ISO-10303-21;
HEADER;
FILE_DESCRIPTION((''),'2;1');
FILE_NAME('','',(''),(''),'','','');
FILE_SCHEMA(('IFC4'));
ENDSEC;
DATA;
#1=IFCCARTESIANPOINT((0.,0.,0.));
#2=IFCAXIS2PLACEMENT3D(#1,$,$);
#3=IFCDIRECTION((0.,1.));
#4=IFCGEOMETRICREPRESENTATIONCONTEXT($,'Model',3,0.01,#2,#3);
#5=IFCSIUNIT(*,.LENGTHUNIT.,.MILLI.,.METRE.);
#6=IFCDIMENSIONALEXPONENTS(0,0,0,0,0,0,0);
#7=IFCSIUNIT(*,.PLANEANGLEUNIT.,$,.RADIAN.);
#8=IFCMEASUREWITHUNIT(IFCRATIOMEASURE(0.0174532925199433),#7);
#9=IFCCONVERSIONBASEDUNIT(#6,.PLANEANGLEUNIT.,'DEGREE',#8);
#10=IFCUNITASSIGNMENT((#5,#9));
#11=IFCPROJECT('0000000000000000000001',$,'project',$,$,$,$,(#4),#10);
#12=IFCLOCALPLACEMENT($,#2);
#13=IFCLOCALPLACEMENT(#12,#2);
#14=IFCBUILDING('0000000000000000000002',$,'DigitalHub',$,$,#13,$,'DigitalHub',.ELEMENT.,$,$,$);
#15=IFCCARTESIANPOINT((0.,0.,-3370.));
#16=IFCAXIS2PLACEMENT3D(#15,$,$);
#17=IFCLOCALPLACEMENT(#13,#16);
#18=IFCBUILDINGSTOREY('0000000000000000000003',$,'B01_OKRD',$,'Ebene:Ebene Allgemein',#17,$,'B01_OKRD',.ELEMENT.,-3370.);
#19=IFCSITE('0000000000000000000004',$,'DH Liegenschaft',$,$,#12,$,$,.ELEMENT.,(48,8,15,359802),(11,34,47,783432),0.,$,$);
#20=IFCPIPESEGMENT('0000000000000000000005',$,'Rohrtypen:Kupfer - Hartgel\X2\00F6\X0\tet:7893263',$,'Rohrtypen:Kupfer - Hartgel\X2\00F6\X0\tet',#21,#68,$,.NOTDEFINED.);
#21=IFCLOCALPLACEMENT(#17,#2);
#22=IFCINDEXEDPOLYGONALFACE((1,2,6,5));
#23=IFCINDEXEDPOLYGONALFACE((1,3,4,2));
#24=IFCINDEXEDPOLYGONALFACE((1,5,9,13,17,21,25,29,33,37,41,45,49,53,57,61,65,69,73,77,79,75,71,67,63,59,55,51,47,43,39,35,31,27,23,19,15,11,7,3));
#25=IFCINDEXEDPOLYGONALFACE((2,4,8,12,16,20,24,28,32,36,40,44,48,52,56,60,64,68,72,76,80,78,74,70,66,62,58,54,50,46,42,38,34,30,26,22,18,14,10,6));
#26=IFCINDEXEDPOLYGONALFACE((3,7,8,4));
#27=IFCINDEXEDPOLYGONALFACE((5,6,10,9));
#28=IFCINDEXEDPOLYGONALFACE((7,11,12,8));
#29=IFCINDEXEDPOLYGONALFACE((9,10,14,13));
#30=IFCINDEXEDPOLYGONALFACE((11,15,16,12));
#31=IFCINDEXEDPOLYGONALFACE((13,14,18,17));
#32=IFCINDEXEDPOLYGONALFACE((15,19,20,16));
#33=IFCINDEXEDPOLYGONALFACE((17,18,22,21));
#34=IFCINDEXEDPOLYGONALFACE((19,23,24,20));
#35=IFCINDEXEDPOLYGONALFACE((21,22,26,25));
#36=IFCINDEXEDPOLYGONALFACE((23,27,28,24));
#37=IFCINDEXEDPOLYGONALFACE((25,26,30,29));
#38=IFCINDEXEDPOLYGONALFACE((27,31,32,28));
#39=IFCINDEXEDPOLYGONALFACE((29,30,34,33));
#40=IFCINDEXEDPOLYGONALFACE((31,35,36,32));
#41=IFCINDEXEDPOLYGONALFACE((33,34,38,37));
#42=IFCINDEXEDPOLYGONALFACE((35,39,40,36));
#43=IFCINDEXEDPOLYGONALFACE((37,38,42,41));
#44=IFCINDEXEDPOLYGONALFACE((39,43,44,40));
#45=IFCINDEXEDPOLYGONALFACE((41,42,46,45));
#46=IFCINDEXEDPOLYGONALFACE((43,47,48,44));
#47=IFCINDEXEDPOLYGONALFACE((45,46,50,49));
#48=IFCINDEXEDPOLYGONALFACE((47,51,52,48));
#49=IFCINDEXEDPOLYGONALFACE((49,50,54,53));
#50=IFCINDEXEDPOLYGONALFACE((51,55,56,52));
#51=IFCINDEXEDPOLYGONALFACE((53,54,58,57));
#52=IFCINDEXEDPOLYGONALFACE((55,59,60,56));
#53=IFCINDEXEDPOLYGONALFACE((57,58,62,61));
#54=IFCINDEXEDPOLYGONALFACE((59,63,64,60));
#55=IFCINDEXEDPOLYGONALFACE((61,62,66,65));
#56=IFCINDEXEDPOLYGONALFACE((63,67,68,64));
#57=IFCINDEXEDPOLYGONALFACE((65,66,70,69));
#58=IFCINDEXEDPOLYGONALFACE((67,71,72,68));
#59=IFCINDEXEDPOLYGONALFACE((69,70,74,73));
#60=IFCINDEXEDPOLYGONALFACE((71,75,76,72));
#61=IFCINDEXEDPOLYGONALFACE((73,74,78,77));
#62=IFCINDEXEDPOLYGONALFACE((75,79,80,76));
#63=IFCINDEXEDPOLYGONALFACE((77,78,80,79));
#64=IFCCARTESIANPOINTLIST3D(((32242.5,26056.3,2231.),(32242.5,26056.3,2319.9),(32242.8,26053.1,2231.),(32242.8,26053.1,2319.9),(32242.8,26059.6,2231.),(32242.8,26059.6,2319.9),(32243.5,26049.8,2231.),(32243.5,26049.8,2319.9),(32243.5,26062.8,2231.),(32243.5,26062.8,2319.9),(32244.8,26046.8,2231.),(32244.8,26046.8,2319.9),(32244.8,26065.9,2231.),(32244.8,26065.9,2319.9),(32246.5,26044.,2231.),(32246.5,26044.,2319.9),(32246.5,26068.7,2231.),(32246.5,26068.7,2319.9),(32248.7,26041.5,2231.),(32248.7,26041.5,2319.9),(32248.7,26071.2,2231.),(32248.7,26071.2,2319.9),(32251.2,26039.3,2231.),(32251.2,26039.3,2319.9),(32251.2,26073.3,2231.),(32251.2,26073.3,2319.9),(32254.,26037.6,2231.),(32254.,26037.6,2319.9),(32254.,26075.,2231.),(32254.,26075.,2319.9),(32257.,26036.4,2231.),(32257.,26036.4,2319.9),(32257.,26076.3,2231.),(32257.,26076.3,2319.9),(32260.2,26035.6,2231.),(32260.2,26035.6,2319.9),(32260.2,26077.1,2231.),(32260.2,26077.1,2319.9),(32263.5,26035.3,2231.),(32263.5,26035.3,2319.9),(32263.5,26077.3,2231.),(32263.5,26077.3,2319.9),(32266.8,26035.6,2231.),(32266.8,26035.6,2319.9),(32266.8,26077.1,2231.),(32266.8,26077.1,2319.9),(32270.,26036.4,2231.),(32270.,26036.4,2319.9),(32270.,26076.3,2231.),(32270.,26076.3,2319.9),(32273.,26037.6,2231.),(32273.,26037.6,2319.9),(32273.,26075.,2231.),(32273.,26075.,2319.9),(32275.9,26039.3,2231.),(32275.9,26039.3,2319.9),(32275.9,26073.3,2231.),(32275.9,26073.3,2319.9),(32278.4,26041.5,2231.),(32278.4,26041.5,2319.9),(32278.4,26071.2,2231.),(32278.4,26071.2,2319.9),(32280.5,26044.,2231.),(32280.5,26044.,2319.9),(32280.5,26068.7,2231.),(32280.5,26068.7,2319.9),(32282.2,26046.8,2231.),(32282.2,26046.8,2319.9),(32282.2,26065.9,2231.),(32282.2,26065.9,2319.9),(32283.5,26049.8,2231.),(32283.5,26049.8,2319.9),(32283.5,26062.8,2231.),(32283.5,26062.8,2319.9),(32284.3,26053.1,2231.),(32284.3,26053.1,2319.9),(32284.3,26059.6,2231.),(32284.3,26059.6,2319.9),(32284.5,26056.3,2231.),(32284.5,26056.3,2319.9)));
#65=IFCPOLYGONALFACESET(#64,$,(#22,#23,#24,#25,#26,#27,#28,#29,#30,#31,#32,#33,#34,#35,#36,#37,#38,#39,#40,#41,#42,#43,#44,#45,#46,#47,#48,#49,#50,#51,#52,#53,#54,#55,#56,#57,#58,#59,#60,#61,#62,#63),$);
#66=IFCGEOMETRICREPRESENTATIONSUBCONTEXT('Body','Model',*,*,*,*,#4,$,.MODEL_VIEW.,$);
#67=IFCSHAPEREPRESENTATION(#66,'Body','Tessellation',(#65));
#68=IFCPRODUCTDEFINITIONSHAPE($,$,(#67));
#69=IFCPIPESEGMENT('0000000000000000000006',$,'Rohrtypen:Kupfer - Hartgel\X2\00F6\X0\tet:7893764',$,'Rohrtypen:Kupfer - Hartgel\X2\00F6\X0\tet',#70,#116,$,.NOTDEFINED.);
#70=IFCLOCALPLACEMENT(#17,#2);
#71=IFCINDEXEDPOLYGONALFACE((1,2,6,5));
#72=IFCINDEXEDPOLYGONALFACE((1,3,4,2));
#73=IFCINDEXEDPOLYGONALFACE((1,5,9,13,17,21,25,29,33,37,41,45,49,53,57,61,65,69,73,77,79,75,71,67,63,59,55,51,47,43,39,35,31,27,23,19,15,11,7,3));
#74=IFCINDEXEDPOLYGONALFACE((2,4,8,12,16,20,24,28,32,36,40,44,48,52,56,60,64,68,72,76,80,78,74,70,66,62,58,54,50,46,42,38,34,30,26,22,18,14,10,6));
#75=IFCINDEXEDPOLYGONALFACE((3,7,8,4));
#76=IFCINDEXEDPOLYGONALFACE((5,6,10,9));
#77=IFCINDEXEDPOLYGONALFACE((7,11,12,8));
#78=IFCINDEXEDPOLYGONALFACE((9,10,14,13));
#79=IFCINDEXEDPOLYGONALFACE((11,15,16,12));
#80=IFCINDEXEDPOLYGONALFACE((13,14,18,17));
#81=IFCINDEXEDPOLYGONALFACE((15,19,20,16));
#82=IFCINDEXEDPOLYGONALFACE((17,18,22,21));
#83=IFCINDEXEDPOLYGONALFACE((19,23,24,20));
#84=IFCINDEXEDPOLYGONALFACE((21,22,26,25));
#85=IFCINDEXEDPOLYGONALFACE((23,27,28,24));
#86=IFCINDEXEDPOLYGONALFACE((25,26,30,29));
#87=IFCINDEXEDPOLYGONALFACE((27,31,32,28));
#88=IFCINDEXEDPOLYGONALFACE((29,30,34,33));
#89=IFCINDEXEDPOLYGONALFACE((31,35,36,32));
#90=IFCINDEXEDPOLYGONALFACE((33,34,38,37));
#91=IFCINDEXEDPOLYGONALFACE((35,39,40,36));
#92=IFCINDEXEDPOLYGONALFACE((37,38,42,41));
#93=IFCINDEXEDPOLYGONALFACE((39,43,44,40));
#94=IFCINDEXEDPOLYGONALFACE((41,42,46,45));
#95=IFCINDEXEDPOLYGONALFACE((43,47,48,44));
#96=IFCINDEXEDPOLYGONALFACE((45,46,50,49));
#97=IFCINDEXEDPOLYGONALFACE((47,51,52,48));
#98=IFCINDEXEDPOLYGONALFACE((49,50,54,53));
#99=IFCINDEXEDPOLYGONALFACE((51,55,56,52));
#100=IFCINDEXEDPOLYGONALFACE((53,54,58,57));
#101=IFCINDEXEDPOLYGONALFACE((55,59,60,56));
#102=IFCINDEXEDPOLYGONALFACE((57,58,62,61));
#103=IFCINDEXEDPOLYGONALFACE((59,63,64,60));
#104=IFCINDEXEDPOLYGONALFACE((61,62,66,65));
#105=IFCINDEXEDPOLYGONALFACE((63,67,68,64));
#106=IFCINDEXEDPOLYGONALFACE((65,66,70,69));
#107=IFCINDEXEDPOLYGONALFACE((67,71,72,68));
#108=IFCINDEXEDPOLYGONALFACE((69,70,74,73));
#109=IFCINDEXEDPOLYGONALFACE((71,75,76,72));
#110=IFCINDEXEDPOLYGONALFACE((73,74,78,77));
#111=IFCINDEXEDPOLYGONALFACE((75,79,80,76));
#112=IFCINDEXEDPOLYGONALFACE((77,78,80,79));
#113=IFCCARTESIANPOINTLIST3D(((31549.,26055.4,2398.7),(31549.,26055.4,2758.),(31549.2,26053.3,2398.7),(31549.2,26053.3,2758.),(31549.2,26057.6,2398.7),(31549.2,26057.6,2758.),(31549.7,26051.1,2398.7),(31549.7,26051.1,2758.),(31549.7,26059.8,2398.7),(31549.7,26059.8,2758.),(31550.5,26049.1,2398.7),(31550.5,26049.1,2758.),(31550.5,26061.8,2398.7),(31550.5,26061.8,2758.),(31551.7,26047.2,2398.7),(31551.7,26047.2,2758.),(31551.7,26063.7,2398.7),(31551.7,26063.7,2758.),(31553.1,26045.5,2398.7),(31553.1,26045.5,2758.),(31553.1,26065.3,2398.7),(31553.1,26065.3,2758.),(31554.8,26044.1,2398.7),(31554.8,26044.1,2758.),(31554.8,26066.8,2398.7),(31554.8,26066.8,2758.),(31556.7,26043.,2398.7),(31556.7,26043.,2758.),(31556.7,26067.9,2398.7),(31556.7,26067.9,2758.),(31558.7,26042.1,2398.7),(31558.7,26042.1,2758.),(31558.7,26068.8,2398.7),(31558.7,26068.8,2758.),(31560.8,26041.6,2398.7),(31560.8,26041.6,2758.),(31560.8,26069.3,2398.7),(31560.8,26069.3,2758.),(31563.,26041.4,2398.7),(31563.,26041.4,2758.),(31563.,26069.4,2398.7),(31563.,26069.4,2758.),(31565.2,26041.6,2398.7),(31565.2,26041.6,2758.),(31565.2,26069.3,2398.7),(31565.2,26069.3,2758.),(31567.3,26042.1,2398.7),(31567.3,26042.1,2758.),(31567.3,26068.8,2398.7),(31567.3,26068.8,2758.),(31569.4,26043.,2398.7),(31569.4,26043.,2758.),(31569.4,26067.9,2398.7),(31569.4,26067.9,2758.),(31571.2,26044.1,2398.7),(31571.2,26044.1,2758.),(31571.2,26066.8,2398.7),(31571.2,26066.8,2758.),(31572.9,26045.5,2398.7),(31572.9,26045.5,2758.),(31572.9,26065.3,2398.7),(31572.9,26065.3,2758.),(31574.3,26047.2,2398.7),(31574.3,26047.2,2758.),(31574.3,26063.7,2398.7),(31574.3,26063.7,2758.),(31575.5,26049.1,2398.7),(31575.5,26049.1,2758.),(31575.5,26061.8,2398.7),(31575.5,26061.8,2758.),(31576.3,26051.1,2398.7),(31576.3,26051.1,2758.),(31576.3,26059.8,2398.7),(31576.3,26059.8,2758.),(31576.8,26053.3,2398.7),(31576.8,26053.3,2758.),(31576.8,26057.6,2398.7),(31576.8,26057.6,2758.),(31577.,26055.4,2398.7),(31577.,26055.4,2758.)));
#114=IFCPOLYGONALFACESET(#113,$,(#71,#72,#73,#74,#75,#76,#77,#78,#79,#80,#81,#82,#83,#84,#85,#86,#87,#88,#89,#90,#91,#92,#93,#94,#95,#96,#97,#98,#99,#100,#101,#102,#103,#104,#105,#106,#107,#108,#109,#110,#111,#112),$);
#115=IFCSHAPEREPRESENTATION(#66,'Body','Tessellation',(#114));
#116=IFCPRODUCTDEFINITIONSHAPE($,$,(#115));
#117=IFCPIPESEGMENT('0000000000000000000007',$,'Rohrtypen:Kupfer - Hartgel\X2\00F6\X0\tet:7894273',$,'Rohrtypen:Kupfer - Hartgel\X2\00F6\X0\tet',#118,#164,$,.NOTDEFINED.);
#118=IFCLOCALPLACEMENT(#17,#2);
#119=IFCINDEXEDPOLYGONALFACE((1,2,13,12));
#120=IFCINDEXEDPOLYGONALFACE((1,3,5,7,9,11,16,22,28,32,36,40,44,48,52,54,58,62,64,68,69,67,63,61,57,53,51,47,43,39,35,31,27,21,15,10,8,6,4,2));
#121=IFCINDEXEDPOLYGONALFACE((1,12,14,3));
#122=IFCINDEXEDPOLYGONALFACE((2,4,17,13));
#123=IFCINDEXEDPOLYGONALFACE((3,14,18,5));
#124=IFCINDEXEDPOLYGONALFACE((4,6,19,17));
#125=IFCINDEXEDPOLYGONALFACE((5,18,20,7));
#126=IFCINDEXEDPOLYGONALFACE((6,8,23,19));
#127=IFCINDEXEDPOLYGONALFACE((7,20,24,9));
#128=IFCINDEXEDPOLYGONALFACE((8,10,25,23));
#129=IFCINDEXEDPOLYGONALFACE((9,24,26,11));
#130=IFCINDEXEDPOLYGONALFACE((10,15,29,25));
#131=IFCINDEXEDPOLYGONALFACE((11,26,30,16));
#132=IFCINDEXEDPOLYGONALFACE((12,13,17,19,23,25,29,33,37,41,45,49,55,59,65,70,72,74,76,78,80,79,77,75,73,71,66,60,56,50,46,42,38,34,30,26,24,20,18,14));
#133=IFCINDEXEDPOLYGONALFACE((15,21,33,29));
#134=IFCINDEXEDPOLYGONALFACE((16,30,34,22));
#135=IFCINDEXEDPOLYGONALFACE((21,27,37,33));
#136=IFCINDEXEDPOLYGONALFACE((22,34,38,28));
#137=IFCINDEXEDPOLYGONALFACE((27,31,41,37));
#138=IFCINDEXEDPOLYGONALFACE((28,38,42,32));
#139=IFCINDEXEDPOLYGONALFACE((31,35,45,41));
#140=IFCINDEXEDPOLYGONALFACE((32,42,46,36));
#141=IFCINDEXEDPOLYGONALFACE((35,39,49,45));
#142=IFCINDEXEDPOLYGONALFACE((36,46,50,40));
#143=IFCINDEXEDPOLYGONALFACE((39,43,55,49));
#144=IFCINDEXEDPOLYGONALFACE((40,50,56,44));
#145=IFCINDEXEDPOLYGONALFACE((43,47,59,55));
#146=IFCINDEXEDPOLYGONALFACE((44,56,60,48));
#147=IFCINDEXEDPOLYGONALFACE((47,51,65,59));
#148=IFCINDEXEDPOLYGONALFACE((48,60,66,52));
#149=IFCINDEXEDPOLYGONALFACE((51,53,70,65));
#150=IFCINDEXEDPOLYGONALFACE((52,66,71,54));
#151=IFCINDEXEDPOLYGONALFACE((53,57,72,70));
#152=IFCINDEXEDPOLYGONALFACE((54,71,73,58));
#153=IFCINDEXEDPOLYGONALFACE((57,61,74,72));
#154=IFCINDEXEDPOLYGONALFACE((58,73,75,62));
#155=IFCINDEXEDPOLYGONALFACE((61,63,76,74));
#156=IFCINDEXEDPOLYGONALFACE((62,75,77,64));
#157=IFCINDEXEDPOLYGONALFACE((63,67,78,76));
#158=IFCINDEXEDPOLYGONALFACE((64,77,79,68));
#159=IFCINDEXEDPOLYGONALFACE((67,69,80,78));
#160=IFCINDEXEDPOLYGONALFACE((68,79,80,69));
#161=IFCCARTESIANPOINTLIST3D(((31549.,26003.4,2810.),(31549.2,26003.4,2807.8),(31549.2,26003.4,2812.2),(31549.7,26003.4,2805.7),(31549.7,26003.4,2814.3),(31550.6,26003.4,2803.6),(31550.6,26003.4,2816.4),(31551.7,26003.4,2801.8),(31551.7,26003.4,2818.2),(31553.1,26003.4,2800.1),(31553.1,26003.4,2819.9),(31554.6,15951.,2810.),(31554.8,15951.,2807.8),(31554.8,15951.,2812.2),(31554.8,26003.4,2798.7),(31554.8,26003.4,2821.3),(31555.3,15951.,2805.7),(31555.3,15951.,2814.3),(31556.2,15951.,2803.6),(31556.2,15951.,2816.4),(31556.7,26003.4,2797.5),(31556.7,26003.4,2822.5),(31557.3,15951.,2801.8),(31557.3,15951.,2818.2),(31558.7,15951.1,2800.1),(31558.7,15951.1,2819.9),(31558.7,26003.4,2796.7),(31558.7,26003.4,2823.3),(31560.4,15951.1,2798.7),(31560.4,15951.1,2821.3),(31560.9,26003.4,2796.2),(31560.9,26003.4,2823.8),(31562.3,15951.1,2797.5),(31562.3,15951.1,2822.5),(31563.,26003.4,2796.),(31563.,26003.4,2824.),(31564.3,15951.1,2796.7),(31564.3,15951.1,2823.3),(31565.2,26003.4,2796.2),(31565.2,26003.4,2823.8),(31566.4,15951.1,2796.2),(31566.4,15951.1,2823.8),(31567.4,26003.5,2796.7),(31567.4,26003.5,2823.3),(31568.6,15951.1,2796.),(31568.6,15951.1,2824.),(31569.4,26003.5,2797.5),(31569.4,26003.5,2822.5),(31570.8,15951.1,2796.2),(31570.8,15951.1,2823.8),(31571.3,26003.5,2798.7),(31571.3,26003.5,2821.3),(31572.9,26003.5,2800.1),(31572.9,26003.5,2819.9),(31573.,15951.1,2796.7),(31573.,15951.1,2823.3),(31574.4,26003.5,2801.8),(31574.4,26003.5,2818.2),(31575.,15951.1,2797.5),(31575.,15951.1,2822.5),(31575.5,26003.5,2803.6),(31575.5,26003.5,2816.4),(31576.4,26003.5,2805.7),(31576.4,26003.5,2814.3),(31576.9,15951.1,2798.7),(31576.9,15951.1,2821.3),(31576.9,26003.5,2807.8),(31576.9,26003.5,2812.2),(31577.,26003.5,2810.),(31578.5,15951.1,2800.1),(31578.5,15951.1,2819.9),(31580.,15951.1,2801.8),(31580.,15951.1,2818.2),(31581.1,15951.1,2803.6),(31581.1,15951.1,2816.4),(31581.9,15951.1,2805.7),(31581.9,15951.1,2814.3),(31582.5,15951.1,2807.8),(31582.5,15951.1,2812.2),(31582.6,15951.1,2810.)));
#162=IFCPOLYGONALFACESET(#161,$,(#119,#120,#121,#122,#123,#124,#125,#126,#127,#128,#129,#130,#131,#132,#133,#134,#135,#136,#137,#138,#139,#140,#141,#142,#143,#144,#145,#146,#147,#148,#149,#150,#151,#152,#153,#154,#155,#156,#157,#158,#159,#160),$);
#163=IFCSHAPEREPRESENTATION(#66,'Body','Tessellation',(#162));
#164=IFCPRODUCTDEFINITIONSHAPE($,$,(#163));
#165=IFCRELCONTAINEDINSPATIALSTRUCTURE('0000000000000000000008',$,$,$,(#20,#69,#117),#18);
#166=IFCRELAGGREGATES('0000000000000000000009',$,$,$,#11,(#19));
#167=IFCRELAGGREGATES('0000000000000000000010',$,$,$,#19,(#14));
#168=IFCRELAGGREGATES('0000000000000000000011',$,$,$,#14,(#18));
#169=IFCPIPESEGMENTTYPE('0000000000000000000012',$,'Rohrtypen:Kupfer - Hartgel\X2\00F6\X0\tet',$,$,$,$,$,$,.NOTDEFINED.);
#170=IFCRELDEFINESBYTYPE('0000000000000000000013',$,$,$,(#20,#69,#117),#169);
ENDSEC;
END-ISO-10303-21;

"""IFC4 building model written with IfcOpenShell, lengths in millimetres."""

from ifc_helpers import new_model, entity, si_unit, converted_unit, direction, frame, origin, place, context, subcontext, project, spatial, indexed_curve, outline, extrude, type_object, element, save


model = new_model("IFC4")

# Units and contexts
model_context = context("Model", 3, precision=0.01, world=origin(), true_north=direction((0.0, 1.0)))
body_context = subcontext(model_context, "Body", "Model", "MODEL_VIEW")
ifc_project = project(units=[si_unit("LENGTHUNIT", "METRE", prefix="MILLI"), converted_unit("PLANEANGLEUNIT", "DEGREE", entity("IfcRatioMeasure", 0.0174532925199433), si_unit("PLANEANGLEUNIT", "RADIAN"), dimensions=[0, 0, 0, 0, 0, 0, 0])], contexts=[model_context])

# Site, building, storey
site_placement = place(None, origin())
site = spatial("IfcSite", under=ifc_project, at=site_placement, Name="DH Liegenschaft", CompositionType="ELEMENT", RefLatitude=(48, 8, 15, 359802), RefLongitude=(11, 34, 47, 783432), RefElevation=0.0)
building_placement = place(site_placement, origin())
building = spatial("IfcBuilding", under=site, at=building_placement, Name="DigitalHub", LongName="DigitalHub", CompositionType="ELEMENT")
storey_placement = place(building_placement, frame((0.0, 0.0, -3370.0)))
storey = spatial("IfcBuildingStorey", under=building, at=storey_placement, Name="B01_OKRD", ObjectType="Ebene:Ebene Allgemein", LongName="B01_OKRD", CompositionType="ELEMENT", Elevation=-3370.0)

# Pipe segments
pipe_segment_type = type_object("IfcPipeSegmentType", Name="Rohrtypen:Kupfer - Hartgelötet", PredefinedType="NOTDEFINED")
pipe_segment_1_placement = place(storey_placement, frame((32240.9, 26033.7, 2231.0)))
element("IfcPipeSegment", 1, at=pipe_segment_1_placement, inside=storey, type_object=pipe_segment_type, Name="Rohrtypen:Kupfer - Hartgelötet:7893263", ObjectType="Rohrtypen:Kupfer - Hartgelötet", PredefinedType="NOTDEFINED", context=body_context, shape_type="SweptSolid", body=[
    extrude(outline(indexed_curve([(21.0, 0.0), (20.7, 3.3), (20.0, 6.5), (18.7, 9.5), (17.0, 12.3), (14.8, 14.8), (12.3, 17.0), (9.5, 18.7), (6.5, 20.0), (3.3, 20.7), (0.0, 21.0), (-3.3, 20.7), (-6.5, 20.0), (-9.5, 18.7), (-12.3, 17.0), (-14.8, 14.8), (-17.0, 12.3), (-18.7, 9.5), (-20.0, 6.5), (-20.7, 3.3), (-21.0, 0.0), (-20.7, -3.3), (-20.0, -6.5), (-18.7, -9.5), (-17.0, -12.3), (-14.8, -14.8), (-12.3, -17.0), (-9.5, -18.7), (-6.5, -20.0), (-3.3, -20.7), (0.0, -21.0), (3.3, -20.7), (6.5, -20.0), (9.5, -18.7), (12.3, -17.0), (14.8, -14.8), (17.0, -12.3), (18.7, -9.5), (20.0, -6.5), (20.7, -3.3), (21.0, 0.0)], self_intersect=False)), frame((22.6, 22.6, 0.0)), (0.0, 0.0, 1.0), 89.0),
])
pipe_segment_2_placement = place(storey_placement, frame((31547.4, 26039.9, 2398.7)))
element("IfcPipeSegment", 2, at=pipe_segment_2_placement, inside=storey, type_object=pipe_segment_type, Name="Rohrtypen:Kupfer - Hartgelötet:7893764", ObjectType="Rohrtypen:Kupfer - Hartgelötet", PredefinedType="NOTDEFINED", context=body_context, shape_type="SweptSolid", body=[
    extrude(outline(indexed_curve([(14.0, 0.0), (13.8, 2.2), (13.3, 4.3), (12.5, 6.4), (11.3, 8.2), (9.9, 9.9), (8.2, 11.3), (6.4, 12.5), (4.3, 13.3), (2.2, 13.8), (0.0, 14.0), (-2.2, 13.8), (-4.3, 13.3), (-6.4, 12.5), (-8.2, 11.3), (-9.9, 9.9), (-11.3, 8.2), (-12.5, 6.4), (-13.3, 4.3), (-13.8, 2.2), (-14.0, 0.0), (-13.8, -2.2), (-13.3, -4.3), (-12.5, -6.4), (-11.3, -8.2), (-9.9, -9.9), (-8.2, -11.3), (-6.4, -12.5), (-4.3, -13.3), (-2.2, -13.8), (0.0, -14.0), (2.2, -13.8), (4.3, -13.3), (6.4, -12.5), (8.2, -11.3), (9.9, -9.9), (11.3, -8.2), (12.5, -6.4), (13.3, -4.3), (13.8, -2.2), (14.0, 0.0)], self_intersect=False)), frame((15.6, 15.6, 0.0), z_axis=(0.0, 0.0, 1.0), x_axis=(-1.0, 0.0, 0.0)), (0.0, 0.0, 1.0), 359.3),
])
pipe_segment_3_placement = place(storey_placement, frame((31547.4, 15951.0, 2794.4)))
element("IfcPipeSegment", 3, at=pipe_segment_3_placement, inside=storey, type_object=pipe_segment_type, Name="Rohrtypen:Kupfer - Hartgelötet:7894273", ObjectType="Rohrtypen:Kupfer - Hartgelötet", PredefinedType="NOTDEFINED", context=body_context, shape_type="SweptSolid", body=[
    extrude(outline(indexed_curve([(14.0, 0.0), (13.8, 2.2), (13.3, 4.3), (12.5, 6.4), (11.3, 8.2), (9.9, 9.9), (8.2, 11.3), (6.4, 12.5), (4.3, 13.3), (2.2, 13.8), (0.0, 14.0), (-2.2, 13.8), (-4.3, 13.3), (-6.4, 12.5), (-8.2, 11.3), (-9.9, 9.9), (-11.3, 8.2), (-12.5, 6.4), (-13.3, 4.3), (-13.8, 2.2), (-14.0, 0.0), (-13.8, -2.2), (-13.3, -4.3), (-12.5, -6.4), (-11.3, -8.2), (-9.9, -9.9), (-8.2, -11.3), (-6.4, -12.5), (-4.3, -13.3), (-2.2, -13.8), (0.0, -14.0), (2.2, -13.8), (4.3, -13.3), (6.4, -12.5), (8.2, -11.3), (9.9, -9.9), (11.3, -8.2), (12.5, -6.4), (13.3, -4.3), (13.8, -2.2), (14.0, 0.0)], self_intersect=False)), frame((15.6, 10052.4, 15.6), z_axis=(0.000555, -1.0, 0.0), x_axis=(-1.0, -0.000555, 0.0)), (0.0, 0.0, 1.0), 10052.4),
])

save(model, "model.ifc")
